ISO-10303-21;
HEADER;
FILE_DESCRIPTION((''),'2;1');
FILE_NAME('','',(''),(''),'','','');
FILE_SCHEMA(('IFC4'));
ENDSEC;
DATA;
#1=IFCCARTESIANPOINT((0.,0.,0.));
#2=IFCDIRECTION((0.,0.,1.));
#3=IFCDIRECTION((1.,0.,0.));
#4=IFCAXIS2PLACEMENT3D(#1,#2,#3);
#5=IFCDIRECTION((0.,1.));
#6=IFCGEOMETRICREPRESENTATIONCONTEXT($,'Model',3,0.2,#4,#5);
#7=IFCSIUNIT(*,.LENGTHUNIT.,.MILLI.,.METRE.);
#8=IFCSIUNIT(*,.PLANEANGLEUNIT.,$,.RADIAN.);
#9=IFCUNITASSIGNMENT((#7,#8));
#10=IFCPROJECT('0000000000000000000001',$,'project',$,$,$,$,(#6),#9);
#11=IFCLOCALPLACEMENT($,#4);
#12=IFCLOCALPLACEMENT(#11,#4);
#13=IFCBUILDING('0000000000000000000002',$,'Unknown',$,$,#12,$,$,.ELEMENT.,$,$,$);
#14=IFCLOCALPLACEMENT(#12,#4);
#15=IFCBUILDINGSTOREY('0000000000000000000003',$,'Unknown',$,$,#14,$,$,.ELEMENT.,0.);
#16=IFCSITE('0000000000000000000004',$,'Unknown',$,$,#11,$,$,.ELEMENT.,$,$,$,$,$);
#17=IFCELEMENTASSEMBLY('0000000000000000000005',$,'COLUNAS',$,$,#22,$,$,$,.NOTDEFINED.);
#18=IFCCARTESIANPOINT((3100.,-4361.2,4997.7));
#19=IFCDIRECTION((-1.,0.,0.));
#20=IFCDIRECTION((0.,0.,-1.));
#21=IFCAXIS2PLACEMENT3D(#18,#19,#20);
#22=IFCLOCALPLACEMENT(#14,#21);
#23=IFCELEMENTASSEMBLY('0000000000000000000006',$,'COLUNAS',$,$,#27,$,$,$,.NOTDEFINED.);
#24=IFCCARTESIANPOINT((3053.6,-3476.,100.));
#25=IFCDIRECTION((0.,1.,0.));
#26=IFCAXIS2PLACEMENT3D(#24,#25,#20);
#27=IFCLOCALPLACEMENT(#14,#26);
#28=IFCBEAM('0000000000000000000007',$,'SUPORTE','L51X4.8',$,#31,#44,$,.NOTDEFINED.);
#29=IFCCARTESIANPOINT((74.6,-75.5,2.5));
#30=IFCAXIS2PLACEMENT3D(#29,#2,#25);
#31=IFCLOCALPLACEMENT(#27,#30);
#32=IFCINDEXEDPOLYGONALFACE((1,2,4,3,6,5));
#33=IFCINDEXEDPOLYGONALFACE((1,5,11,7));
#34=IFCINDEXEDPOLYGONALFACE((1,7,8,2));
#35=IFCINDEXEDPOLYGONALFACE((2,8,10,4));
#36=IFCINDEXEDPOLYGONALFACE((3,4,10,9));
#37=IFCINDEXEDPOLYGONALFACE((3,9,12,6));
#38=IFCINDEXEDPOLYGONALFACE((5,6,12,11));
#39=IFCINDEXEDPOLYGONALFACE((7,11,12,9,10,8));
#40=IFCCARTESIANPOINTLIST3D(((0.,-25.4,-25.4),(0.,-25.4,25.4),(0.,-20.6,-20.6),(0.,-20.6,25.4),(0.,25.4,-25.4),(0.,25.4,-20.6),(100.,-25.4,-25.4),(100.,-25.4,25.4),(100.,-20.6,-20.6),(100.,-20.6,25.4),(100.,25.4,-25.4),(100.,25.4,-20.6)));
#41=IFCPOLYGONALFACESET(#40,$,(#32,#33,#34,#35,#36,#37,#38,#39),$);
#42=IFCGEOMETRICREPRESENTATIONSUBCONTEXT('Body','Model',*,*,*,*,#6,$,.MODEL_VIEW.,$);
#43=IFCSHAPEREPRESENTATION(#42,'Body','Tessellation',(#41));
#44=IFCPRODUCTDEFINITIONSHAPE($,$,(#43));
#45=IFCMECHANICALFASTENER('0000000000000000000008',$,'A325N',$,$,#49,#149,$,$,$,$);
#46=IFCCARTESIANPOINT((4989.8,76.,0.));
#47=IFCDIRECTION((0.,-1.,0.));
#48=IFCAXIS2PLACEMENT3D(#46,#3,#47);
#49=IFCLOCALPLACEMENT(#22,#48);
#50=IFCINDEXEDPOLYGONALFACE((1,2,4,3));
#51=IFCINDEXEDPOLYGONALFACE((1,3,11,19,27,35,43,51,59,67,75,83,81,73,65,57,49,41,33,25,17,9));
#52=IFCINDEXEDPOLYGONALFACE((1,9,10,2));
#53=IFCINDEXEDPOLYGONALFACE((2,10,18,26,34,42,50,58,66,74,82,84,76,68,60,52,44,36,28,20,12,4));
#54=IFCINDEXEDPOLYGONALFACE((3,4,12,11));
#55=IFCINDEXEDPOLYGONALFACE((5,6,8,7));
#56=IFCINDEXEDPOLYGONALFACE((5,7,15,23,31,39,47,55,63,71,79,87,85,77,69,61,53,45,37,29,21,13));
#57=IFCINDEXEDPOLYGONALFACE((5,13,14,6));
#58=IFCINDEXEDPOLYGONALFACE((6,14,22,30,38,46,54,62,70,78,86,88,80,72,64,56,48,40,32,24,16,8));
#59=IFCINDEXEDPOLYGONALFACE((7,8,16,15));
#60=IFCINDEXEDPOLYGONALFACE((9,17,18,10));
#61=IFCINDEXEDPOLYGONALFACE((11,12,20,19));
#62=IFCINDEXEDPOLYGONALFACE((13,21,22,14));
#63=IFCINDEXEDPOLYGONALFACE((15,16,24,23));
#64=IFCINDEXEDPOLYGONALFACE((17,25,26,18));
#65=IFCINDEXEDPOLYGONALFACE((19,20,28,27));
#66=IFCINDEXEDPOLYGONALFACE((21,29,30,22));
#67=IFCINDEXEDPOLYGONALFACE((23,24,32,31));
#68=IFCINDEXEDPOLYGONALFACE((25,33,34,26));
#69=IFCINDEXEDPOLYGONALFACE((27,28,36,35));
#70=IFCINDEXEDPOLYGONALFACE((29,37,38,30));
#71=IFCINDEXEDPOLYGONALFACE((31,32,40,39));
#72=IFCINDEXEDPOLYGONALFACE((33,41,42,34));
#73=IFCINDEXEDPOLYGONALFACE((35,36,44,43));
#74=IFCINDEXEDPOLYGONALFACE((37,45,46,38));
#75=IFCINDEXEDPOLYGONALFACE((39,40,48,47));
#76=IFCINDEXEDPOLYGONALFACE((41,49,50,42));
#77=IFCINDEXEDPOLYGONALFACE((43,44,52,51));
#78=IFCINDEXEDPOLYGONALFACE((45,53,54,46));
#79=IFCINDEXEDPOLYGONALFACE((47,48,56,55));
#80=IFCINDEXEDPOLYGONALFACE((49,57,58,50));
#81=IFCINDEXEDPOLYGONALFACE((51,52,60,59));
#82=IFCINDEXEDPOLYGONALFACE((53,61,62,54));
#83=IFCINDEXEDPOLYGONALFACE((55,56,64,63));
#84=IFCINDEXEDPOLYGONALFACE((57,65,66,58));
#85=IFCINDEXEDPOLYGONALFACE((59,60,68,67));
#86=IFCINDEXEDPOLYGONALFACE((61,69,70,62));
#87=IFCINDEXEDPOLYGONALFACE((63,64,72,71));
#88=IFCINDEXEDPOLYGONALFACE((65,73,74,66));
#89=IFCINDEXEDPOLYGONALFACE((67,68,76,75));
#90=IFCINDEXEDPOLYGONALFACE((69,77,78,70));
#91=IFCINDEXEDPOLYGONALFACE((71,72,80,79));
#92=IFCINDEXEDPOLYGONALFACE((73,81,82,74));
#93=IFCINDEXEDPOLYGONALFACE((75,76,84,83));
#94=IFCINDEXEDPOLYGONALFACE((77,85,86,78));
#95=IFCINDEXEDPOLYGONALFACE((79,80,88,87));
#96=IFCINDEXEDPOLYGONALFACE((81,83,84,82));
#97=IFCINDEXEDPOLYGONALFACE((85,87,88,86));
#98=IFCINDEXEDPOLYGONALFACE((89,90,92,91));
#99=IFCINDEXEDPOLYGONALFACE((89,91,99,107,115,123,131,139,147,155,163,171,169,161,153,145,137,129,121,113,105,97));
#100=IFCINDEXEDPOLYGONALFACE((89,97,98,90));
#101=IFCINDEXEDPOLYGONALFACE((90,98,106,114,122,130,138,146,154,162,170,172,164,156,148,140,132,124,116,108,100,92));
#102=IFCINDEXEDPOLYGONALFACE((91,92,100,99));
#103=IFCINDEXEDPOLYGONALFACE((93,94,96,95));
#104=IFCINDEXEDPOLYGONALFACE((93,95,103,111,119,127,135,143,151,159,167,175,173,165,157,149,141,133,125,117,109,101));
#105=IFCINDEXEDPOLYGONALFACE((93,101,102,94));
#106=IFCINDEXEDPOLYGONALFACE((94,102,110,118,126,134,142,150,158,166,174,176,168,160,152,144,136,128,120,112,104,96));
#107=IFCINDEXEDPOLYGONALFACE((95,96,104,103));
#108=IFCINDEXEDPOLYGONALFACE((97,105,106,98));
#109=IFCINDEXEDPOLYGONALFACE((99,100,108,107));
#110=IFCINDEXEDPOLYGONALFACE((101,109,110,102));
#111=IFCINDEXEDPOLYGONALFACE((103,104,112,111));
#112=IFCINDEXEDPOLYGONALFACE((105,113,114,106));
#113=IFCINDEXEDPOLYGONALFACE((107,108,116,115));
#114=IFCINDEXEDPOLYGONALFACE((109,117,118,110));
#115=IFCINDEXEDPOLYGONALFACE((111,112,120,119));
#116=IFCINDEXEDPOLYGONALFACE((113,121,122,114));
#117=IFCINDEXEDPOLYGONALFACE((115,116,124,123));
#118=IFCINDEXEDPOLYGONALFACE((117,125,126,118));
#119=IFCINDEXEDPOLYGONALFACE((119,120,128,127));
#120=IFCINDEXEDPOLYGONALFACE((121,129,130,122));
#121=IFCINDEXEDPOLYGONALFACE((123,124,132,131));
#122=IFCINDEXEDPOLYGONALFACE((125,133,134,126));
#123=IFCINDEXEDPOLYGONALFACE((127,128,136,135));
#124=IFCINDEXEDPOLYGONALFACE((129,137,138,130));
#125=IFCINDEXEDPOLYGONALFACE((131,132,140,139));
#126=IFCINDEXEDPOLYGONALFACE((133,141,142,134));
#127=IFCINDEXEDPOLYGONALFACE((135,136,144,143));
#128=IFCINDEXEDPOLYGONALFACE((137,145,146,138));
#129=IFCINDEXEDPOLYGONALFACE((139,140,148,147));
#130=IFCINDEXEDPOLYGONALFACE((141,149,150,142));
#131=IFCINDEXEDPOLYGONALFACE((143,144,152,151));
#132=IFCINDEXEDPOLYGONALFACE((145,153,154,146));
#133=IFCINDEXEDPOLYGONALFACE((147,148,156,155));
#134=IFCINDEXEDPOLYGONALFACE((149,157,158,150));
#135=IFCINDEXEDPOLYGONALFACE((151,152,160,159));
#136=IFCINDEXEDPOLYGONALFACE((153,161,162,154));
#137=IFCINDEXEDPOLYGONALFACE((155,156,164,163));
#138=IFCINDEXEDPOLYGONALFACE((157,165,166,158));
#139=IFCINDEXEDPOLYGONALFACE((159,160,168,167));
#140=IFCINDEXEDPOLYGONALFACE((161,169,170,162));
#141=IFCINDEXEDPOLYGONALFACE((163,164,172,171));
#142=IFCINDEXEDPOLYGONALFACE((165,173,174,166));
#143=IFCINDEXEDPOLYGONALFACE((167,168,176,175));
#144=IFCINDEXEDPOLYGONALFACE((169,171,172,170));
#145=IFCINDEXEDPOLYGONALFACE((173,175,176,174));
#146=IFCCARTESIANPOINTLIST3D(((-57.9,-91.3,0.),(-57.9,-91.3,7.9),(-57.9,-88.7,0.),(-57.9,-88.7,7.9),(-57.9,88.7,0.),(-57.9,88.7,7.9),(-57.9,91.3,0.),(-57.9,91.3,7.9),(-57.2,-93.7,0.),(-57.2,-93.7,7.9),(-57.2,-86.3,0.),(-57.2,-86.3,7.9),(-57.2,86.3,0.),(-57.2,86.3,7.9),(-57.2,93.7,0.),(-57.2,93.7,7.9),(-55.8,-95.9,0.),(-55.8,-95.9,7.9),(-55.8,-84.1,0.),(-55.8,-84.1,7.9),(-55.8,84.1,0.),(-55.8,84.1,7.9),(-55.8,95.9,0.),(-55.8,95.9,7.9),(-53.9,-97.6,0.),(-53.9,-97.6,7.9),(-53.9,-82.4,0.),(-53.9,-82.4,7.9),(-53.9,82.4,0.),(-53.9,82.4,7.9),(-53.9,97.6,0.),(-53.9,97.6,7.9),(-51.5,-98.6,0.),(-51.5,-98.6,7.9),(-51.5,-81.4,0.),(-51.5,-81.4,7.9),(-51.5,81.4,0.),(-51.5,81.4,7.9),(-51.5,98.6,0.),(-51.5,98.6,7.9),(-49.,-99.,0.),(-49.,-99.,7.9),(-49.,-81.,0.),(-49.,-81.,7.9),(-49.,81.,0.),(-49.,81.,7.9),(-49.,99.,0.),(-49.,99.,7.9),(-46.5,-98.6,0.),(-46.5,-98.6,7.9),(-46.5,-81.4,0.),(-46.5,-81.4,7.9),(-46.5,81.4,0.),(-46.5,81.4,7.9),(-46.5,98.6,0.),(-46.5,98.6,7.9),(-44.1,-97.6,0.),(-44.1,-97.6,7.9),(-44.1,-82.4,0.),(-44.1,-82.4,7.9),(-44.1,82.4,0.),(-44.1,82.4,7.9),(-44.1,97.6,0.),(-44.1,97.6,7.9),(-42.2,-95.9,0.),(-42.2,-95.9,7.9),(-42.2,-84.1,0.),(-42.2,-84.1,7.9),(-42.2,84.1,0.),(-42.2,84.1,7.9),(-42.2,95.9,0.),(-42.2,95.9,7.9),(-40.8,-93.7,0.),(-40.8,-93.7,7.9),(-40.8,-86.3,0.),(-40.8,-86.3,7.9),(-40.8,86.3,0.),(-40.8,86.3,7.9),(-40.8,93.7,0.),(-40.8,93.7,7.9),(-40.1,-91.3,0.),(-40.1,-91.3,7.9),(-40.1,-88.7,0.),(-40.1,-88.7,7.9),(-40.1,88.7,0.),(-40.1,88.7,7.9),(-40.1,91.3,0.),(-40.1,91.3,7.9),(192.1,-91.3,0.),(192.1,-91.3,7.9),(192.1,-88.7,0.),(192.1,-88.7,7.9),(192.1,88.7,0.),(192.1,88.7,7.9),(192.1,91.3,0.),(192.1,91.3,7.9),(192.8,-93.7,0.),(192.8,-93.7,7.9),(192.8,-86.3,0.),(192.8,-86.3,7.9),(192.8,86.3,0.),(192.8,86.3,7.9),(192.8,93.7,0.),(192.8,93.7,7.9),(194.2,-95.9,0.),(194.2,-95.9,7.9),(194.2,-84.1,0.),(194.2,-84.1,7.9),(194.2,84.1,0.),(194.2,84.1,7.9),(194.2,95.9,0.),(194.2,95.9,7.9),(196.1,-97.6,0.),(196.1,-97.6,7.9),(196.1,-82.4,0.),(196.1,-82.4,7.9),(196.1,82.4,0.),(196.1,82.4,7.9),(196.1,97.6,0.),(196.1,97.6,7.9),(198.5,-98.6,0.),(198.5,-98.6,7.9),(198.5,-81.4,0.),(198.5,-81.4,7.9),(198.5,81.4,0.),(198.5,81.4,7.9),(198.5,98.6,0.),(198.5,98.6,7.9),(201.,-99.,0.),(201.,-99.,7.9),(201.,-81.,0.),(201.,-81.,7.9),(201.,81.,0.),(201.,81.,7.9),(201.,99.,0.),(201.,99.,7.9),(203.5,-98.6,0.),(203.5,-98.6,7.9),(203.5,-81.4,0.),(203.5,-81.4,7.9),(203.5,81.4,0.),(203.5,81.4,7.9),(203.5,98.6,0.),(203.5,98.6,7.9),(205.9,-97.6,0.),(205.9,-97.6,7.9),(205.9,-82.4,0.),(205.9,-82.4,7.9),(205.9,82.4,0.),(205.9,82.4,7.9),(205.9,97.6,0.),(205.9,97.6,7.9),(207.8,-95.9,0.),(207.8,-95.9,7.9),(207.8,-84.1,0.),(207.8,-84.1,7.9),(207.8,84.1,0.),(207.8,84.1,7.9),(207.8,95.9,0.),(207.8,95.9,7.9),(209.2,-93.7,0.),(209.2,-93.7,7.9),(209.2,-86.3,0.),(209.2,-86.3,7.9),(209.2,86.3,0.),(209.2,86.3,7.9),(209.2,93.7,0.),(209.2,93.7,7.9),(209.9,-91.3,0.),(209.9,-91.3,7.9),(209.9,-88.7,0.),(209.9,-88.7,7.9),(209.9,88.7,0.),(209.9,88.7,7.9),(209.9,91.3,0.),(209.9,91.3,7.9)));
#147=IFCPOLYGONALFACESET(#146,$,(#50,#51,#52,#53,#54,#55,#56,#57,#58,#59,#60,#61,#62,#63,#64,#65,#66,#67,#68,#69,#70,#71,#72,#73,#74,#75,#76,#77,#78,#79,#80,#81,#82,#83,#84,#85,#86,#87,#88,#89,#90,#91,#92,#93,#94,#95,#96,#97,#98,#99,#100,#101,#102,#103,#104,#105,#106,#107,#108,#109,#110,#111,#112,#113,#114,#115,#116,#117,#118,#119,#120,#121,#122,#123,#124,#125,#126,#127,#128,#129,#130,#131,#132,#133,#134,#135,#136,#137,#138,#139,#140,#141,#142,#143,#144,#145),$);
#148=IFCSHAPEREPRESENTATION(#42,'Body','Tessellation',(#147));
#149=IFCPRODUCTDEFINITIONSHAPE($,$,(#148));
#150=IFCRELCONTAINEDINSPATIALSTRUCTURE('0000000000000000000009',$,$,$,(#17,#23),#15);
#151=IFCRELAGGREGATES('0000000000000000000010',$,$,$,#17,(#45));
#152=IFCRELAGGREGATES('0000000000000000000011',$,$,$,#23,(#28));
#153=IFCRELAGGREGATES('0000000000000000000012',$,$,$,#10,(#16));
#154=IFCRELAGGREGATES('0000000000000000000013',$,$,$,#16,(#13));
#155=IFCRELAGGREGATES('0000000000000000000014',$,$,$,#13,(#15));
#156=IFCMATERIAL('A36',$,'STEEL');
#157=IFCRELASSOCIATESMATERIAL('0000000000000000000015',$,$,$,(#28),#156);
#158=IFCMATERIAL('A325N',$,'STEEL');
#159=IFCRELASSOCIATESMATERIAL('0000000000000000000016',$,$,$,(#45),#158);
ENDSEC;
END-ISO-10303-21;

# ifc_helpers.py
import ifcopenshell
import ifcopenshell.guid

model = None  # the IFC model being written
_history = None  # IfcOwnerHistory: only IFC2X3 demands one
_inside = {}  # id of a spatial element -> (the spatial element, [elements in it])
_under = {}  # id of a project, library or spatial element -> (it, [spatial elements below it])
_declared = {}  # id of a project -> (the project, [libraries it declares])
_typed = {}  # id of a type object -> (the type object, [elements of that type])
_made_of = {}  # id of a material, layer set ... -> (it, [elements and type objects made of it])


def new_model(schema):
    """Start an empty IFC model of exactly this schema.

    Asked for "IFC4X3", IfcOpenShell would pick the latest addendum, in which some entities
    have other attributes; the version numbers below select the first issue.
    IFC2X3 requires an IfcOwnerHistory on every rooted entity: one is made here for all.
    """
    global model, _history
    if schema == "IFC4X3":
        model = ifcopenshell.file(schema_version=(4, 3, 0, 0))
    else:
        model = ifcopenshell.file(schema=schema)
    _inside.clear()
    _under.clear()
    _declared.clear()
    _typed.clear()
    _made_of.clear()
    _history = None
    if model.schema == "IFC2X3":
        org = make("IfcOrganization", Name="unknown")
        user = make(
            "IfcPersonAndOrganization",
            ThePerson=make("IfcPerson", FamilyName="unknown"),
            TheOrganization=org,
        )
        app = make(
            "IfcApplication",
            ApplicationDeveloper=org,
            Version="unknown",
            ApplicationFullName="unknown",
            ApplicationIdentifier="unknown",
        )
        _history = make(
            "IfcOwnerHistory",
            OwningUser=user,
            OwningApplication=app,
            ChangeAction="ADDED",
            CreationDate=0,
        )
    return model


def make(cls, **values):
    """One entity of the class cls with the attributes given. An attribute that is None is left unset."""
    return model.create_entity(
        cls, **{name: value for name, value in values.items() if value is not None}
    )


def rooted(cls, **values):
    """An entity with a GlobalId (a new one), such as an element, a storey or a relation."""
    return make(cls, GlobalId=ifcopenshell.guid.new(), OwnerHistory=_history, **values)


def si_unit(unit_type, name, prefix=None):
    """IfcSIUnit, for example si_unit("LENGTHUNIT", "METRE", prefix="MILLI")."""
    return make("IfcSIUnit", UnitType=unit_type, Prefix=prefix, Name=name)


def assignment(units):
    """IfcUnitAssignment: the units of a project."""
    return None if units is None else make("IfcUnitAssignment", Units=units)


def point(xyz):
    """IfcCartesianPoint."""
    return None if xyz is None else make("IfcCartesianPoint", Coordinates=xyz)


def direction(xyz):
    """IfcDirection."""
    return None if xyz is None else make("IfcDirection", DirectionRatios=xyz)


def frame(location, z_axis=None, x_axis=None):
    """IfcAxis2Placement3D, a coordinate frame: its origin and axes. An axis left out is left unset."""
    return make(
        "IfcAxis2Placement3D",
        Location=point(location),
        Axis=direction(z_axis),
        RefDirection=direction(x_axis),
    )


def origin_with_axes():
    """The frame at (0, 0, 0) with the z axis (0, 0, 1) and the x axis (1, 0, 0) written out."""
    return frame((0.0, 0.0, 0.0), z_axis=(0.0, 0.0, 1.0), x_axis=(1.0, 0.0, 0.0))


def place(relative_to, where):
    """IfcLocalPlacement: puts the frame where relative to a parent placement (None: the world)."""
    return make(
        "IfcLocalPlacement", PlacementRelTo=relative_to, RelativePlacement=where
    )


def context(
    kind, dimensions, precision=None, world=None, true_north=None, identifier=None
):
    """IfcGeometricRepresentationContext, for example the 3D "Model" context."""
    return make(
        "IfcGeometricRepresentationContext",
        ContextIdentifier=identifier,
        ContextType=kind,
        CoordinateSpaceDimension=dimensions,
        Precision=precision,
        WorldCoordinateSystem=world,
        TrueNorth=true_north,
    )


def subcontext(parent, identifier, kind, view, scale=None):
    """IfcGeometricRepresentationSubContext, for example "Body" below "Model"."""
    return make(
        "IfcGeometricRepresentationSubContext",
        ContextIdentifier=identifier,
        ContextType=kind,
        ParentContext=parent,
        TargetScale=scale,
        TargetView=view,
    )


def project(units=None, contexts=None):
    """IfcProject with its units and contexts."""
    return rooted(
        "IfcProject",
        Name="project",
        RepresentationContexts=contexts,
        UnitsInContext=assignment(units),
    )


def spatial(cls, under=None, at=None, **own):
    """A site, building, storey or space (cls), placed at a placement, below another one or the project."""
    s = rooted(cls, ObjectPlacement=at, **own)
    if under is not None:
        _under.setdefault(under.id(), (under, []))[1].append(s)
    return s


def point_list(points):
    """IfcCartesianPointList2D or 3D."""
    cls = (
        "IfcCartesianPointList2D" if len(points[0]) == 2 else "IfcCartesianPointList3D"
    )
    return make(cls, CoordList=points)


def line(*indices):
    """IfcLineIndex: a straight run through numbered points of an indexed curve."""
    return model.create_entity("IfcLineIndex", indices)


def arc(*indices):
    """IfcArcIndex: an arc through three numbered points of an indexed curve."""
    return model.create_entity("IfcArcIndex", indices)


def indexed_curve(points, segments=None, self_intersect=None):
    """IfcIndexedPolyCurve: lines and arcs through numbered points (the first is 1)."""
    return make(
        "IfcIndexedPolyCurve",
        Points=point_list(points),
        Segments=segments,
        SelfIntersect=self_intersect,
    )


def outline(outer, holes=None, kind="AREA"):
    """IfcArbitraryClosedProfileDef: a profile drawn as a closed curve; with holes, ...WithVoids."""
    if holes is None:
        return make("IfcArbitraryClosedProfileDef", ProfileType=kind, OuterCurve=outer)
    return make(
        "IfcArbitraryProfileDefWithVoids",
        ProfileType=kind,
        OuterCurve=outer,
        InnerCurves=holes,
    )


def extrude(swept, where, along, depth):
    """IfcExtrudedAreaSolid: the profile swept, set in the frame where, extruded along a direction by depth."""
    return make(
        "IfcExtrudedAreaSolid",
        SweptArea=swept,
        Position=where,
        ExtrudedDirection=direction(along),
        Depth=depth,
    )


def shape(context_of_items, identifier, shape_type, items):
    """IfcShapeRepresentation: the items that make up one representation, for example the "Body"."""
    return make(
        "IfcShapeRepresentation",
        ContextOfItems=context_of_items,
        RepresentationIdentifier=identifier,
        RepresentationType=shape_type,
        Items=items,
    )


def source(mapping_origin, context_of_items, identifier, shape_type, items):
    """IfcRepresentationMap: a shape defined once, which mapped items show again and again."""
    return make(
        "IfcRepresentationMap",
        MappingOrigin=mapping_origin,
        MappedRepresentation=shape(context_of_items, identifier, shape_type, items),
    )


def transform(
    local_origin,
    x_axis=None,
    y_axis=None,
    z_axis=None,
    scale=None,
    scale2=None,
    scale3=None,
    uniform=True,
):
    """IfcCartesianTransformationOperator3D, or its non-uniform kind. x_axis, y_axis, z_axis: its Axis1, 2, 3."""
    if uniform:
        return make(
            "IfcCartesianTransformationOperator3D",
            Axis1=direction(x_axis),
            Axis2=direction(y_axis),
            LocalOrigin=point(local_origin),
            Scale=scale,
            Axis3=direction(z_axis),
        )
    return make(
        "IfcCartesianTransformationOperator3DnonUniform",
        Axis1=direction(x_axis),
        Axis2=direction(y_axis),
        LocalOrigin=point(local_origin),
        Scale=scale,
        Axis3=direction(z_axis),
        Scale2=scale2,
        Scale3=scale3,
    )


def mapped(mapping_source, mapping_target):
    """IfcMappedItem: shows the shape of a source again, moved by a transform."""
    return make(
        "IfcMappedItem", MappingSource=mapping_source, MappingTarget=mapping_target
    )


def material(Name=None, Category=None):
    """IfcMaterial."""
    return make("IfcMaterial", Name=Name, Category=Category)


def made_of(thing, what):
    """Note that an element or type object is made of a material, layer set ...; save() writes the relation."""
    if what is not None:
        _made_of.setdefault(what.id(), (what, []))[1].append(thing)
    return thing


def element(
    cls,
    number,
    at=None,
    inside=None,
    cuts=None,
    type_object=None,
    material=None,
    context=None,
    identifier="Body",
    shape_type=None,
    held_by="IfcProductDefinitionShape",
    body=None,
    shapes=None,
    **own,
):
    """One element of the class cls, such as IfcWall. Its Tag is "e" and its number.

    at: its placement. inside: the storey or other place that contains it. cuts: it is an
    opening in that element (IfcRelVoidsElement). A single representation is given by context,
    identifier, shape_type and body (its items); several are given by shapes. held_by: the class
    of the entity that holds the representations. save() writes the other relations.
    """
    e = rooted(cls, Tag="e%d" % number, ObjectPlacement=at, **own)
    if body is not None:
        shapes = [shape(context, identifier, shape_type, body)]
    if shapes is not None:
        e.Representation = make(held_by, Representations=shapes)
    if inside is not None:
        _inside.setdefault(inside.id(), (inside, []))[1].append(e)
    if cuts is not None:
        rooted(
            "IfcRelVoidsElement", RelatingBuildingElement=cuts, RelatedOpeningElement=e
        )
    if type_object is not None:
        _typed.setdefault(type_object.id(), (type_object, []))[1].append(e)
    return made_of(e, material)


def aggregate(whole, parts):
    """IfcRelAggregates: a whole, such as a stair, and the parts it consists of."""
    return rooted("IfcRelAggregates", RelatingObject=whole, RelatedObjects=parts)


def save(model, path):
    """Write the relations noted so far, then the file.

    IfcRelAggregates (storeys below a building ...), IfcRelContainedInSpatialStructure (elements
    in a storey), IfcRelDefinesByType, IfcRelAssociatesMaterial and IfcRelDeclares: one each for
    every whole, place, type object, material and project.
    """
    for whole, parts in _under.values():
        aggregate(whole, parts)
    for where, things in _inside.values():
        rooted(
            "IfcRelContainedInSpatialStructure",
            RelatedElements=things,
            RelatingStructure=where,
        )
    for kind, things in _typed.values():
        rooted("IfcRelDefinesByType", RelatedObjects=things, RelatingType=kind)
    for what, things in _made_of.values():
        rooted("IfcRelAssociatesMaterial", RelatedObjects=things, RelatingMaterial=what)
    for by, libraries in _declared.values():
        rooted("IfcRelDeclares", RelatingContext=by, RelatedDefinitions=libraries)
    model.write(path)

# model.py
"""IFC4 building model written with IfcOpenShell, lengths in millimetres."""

from ifc_helpers import new_model, si_unit, direction, frame, origin_with_axes, place, context, subcontext, project, spatial, line, arc, indexed_curve, outline, extrude, source, transform, mapped, material, element, aggregate, save


model = new_model("IFC4")

# Units and contexts
model_context = context("Model", 3, precision=0.2, world=origin_with_axes(), true_north=direction((0.0, 1.0)))
body_context = subcontext(model_context, "Body", "Model", "MODEL_VIEW")
ifc_project = project(units=[si_unit("LENGTHUNIT", "METRE", prefix="MILLI"), si_unit("PLANEANGLEUNIT", "RADIAN")], contexts=[model_context])

# Site, building, storey
site_placement = place(None, origin_with_axes())
site = spatial("IfcSite", under=ifc_project, at=site_placement, Name="Unknown", CompositionType="ELEMENT")
building_placement = place(site_placement, origin_with_axes())
building = spatial("IfcBuilding", under=site, at=building_placement, Name="Unknown", CompositionType="ELEMENT")
storey_placement = place(building_placement, origin_with_axes())
storey = spatial("IfcBuildingStorey", under=building, at=storey_placement, Name="Unknown", CompositionType="ELEMENT", Elevation=0.0)

# Element assembly
assembly_1_placement = place(storey_placement, frame((3100.0, -4361.2, 4997.7), z_axis=(-1.0, 0.0, 0.0), x_axis=(0.0, 0.0, -1.0)))
assembly_1 = element("IfcElementAssembly", 1, at=assembly_1_placement, inside=storey, Name="COLUNAS", PredefinedType="NOTDEFINED")
ifc_material_1 = material(Name="A36", Category="STEEL")

# Element assembly, beam
assembly_2_placement = place(storey_placement, frame((3053.6, -3476.0, 100.0), z_axis=(0.0, 1.0, 0.0), x_axis=(0.0, 0.0, -1.0)))
assembly_2 = element("IfcElementAssembly", 2, at=assembly_2_placement, inside=storey, Name="COLUNAS", PredefinedType="NOTDEFINED")
beam_1_placement = place(assembly_2_placement, frame((74.6, -75.5, 2.5), z_axis=(0.0, 0.0, 1.0), x_axis=(0.0, 1.0, 0.0)))
beam_1 = element("IfcBeam", 3, at=beam_1_placement, material=ifc_material_1, Name="SUPORTE", Description="L51X4.8", PredefinedType="NOTDEFINED", context=body_context, shape_type="SolidModel", body=[
    extrude(outline(indexed_curve([(-25.4, -25.4), (25.4, -25.4), (25.4, -20.6), (-20.6, -20.6), (-20.6, 25.4), (-25.4, 25.4)], segments=[line(1, 2, 3, 4, 5, 6, 1)])), frame((0.0, 0.0, 0.0), z_axis=(-1.0, 0.0, 0.0), x_axis=(0.0, 0.0, 1.0)), (0.0, 0.0, -1.0), 100.0),
])

# Mechanical fastener
ifc_material_2 = material(Name="A325N", Category="STEEL")
shared_shape_1 = source(origin_with_axes(), body_context, "Body", "SweptSolid", [
    extrude(outline(indexed_curve([(9.0, 0.0), (0.0, 9.0), (-9.0, 0.0), (0.0, -9.0)], segments=[arc(1, 2, 3), arc(3, 4, 1)])), frame((0.0, 0.0, 7.9), z_axis=(0.0, 0.0, -1.0), x_axis=(0.0, 1.0, 0.0)), (0.0, 0.0, 1.0), 7.9),
])
mechanical_fastener_1_placement = place(assembly_1_placement, frame((4989.8, 76.0, 0.0), z_axis=(1.0, 0.0, 0.0), x_axis=(0.0, -1.0, 0.0)))
mechanical_fastener_1 = element("IfcMechanicalFastener", 4, at=mechanical_fastener_1_placement, material=ifc_material_2, Name="A325N", context=body_context, shape_type="MappedRepresentation", body=[
    mapped(shared_shape_1, transform((-49.0, -90.0, 0.0))),
    mapped(shared_shape_1, transform((-49.0, 90.0, 0.0))),
    mapped(shared_shape_1, transform((201.0, -90.0, 0.0))),
    mapped(shared_shape_1, transform((201.0, 90.0, 0.0))),
])
aggregate(assembly_1, [mechanical_fastener_1])
aggregate(assembly_2, [beam_1])

save(model, "model.ifc")
